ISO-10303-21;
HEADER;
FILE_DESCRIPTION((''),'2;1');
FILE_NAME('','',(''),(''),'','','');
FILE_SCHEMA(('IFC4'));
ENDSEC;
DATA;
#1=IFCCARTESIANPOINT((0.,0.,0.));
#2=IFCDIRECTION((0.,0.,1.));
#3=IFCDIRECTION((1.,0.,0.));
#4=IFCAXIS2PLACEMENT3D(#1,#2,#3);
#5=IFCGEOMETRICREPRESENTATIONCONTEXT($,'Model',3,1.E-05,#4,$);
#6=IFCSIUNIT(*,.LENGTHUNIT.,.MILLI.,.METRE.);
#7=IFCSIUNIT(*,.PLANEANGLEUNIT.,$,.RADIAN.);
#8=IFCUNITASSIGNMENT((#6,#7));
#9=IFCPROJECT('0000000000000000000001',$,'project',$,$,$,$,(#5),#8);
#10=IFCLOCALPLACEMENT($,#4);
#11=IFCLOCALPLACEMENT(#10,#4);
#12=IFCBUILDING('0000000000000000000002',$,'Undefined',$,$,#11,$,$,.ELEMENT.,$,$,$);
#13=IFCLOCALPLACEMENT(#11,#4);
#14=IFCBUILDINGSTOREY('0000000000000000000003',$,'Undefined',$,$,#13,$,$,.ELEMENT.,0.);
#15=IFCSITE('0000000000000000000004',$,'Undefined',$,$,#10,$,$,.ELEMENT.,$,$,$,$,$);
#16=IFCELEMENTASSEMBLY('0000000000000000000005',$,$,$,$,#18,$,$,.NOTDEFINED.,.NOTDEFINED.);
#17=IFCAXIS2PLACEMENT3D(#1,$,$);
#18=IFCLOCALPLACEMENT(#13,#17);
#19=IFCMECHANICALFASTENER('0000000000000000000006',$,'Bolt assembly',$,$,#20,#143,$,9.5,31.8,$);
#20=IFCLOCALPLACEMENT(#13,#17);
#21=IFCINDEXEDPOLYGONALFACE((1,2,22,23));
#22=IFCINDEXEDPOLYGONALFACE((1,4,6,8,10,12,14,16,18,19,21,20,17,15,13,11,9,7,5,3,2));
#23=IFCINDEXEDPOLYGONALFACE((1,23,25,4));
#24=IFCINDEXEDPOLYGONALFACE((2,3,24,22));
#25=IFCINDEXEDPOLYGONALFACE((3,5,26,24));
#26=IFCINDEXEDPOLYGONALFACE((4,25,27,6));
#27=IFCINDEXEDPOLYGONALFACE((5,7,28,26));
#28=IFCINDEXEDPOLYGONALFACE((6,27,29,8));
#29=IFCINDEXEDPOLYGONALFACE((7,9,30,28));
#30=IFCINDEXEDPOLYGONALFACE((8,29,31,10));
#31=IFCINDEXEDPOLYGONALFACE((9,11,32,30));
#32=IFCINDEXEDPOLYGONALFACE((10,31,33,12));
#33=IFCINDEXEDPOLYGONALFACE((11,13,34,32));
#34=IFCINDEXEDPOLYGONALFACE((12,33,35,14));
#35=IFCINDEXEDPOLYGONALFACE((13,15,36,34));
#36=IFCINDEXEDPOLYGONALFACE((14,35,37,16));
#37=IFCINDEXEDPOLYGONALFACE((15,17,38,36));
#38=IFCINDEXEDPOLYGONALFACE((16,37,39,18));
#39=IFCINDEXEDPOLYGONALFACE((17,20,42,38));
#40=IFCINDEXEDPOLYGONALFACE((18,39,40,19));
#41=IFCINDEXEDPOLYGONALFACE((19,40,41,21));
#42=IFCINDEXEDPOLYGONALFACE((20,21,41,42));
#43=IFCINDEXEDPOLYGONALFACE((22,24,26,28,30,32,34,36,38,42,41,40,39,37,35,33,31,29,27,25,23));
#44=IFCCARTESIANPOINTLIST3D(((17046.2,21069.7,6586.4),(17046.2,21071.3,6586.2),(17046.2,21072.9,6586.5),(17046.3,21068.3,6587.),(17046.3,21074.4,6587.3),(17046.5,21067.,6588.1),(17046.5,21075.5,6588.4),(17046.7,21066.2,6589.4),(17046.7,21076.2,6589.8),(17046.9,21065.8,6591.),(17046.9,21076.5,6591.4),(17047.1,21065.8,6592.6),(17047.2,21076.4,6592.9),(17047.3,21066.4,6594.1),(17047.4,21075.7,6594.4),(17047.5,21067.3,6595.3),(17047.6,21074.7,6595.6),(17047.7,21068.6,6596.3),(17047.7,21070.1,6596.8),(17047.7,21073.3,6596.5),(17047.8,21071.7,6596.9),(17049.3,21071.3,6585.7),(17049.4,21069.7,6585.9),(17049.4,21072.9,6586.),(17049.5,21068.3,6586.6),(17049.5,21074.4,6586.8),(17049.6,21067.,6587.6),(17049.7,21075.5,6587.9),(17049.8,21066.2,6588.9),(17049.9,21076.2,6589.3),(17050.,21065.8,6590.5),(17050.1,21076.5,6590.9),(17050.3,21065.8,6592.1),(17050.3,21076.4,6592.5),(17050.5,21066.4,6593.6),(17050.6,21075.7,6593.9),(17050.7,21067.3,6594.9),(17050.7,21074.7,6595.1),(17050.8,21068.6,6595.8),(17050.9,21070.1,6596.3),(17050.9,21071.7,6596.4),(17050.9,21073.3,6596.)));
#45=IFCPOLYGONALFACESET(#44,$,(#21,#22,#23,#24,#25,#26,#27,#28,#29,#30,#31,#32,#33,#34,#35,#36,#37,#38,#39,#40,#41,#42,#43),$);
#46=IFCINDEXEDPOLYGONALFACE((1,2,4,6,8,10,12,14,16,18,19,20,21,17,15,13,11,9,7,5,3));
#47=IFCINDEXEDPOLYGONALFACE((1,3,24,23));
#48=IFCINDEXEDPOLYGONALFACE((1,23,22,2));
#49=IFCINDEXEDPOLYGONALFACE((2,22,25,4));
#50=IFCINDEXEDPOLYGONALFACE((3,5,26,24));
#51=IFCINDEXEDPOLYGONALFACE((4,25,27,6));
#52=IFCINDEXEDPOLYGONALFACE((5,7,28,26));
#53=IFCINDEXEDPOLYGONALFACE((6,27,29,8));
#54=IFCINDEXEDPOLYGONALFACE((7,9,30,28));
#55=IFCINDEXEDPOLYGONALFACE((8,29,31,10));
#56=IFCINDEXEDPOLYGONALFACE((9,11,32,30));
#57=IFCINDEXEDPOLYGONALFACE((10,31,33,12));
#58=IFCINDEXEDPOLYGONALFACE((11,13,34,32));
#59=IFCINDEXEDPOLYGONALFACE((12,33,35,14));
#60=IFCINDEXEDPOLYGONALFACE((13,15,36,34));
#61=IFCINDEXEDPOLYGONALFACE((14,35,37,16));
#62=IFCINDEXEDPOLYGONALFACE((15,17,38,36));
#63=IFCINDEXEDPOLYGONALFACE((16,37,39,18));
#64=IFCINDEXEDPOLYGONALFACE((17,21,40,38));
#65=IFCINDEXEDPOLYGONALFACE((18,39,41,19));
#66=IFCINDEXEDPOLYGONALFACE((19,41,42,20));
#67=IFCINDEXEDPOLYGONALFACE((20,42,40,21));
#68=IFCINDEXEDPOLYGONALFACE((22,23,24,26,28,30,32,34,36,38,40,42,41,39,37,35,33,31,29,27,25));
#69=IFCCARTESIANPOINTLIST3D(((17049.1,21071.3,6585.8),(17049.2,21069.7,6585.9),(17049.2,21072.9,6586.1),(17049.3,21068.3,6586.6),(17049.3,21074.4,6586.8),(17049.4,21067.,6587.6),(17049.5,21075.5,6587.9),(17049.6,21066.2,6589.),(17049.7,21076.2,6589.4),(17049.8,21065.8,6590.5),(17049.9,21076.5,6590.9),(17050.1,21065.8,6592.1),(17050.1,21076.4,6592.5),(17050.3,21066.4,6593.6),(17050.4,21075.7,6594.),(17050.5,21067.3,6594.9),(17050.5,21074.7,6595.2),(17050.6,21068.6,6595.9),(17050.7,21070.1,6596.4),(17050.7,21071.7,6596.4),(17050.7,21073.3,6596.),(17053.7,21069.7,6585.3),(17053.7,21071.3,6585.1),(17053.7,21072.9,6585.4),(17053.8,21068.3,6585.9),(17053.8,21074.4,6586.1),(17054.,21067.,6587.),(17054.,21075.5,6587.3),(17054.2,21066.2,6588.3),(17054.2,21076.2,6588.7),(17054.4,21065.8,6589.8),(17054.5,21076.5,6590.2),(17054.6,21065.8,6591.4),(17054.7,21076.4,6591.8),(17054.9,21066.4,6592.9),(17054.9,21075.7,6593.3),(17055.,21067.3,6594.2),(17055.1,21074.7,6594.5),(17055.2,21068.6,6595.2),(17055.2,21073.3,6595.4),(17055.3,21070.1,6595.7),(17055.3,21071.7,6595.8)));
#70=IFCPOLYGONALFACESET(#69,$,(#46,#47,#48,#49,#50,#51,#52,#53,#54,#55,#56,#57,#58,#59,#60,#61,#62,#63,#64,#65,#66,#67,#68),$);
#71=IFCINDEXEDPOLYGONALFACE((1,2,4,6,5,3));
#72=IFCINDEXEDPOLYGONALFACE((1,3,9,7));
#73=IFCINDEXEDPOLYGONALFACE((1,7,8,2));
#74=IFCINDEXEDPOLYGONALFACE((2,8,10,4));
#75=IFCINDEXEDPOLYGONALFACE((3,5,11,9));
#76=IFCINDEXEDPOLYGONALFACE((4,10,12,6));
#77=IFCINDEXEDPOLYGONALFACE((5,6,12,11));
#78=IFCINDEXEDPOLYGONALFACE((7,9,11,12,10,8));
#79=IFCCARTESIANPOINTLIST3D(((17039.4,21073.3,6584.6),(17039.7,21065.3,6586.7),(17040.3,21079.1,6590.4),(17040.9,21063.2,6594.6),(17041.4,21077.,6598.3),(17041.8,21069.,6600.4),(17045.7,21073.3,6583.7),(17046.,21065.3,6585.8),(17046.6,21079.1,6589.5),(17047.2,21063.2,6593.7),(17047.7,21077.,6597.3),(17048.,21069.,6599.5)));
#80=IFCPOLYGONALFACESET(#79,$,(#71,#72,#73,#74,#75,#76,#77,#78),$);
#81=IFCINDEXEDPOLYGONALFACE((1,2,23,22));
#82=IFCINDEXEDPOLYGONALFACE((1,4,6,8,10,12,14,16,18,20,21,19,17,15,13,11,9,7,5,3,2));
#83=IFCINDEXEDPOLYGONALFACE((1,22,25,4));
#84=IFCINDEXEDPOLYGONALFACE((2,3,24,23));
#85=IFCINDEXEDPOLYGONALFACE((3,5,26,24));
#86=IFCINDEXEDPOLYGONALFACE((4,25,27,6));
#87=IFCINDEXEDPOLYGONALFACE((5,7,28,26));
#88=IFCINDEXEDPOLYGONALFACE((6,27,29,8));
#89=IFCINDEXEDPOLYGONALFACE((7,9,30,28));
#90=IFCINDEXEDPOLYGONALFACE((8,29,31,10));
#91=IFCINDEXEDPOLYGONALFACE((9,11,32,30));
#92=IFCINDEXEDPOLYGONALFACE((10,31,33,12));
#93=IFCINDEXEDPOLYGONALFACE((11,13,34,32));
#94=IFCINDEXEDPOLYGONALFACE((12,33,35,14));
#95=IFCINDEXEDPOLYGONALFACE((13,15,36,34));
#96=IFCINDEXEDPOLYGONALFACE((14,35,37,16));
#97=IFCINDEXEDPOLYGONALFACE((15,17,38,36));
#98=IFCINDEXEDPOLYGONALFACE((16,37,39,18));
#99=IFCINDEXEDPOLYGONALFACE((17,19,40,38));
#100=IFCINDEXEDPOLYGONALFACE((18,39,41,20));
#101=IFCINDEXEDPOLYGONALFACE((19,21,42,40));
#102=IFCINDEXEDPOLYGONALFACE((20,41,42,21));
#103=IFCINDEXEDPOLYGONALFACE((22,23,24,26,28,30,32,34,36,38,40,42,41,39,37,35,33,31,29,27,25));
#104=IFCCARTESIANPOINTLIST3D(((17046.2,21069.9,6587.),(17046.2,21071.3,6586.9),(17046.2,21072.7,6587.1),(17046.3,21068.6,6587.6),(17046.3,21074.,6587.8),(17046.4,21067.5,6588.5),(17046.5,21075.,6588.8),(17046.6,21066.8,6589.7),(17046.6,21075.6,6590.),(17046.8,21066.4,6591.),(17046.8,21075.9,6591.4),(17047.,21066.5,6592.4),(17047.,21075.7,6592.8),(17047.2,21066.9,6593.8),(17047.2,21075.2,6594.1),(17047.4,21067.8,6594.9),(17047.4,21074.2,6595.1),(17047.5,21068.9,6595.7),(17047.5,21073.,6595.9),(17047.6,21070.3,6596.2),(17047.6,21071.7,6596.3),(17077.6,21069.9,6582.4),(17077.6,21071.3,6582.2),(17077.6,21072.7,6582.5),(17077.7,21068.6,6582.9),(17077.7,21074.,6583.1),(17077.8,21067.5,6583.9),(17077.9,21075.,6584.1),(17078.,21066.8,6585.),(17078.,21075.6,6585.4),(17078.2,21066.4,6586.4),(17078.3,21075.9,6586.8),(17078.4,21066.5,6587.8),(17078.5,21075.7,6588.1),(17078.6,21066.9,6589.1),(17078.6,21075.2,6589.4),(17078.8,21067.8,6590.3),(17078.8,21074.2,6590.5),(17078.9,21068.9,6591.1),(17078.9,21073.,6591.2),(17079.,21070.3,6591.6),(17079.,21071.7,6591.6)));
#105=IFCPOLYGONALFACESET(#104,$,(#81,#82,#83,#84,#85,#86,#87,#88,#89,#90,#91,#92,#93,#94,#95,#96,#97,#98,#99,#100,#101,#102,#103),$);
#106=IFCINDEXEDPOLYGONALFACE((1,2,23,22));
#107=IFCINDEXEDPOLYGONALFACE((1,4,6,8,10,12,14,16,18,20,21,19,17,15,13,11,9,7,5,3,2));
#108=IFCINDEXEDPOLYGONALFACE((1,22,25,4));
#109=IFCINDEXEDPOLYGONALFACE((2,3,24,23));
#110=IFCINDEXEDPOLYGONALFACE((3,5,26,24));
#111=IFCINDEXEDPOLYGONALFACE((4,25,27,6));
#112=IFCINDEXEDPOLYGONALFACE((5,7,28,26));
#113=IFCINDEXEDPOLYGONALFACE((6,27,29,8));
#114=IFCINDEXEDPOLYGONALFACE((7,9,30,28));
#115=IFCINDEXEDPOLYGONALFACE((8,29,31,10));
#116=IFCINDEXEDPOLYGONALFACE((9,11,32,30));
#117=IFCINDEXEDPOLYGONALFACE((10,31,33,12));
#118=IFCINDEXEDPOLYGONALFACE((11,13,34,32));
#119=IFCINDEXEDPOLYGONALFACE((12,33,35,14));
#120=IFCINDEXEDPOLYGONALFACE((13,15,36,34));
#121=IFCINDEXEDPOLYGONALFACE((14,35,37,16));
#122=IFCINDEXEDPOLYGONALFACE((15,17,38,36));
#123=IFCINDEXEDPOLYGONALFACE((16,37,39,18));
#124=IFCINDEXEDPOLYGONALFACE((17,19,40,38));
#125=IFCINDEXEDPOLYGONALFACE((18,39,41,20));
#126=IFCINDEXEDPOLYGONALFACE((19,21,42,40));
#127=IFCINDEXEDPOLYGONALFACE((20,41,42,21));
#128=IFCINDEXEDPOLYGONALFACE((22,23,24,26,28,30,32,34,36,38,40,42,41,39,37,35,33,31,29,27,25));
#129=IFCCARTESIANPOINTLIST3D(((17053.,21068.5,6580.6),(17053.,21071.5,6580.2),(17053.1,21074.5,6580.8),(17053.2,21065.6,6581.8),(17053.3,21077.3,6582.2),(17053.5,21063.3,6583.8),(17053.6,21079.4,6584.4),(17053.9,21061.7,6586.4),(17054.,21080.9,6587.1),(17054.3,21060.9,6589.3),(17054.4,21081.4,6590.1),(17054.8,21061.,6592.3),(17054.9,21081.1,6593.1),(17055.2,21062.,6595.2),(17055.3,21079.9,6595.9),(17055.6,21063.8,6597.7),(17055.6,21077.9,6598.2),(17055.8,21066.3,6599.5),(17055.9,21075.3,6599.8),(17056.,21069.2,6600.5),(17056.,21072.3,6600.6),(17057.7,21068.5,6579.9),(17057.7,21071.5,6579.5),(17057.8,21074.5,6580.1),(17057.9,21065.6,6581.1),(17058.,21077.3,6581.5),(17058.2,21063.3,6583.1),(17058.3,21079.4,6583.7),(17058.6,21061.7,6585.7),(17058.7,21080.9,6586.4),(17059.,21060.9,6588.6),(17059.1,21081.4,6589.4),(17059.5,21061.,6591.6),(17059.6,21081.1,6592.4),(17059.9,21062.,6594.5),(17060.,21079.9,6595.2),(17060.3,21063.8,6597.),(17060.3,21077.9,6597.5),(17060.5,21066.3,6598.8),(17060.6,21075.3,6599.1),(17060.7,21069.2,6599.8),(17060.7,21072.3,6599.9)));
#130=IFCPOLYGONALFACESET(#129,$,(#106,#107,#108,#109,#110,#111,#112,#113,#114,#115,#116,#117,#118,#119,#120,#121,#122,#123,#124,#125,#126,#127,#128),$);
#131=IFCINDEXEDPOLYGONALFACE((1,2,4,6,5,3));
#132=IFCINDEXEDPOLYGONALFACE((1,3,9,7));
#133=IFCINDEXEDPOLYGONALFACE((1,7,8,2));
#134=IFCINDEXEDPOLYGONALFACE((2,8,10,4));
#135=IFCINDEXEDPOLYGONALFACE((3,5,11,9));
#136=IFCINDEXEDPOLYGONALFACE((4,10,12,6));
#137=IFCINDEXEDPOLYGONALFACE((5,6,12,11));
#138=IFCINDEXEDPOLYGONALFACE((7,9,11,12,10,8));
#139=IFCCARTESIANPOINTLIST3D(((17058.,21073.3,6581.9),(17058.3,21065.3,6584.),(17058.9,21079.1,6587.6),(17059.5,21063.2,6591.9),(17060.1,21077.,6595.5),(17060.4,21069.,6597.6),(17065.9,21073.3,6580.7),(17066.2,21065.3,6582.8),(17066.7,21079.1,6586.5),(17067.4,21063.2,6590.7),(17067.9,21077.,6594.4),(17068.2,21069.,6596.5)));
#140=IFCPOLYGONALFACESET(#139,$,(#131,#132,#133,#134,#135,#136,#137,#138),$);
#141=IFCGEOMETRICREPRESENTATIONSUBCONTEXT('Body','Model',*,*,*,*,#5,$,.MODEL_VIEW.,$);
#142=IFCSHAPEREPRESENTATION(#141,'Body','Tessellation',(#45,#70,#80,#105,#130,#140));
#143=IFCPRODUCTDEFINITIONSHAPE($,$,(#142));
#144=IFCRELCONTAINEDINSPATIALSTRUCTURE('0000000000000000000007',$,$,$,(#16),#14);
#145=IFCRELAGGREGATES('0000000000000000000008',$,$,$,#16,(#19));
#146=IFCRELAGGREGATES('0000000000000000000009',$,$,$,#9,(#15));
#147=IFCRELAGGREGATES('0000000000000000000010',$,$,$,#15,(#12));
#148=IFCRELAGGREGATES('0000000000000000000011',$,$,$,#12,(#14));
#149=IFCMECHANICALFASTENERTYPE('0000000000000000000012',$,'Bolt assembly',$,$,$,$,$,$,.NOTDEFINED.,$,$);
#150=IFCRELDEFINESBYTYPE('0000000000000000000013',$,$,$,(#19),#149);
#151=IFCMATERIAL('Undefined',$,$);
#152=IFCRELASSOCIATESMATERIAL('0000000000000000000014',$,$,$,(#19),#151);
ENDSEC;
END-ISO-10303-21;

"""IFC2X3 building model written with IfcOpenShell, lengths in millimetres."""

from ifc_helpers import new_model, si_unit, frame, origin_with_axes, origin_2d_with_axis, place, context, subcontext, project, spatial, polyline, circle, outline, extrude, source, transform, mapped, material, type_object, element, aggregate, save


model = new_model("IFC2X3")

# Units and contexts
model_context = context("Model", 3, precision=1e-05, world=origin_with_axes())
body_context = subcontext(model_context, "Body", "Model", "MODEL_VIEW")
ifc_project = project(units=[si_unit("LENGTHUNIT", "METRE", prefix="MILLI"), si_unit("PLANEANGLEUNIT", "RADIAN")], contexts=[model_context])

# Site, building, storey
site_placement = place(None, origin_with_axes())
site = spatial("IfcSite", under=ifc_project, at=site_placement, Name="Undefined", CompositionType="ELEMENT")
building_placement = place(site_placement, origin_with_axes())
building = spatial("IfcBuilding", under=site, at=building_placement, Name="Undefined", CompositionType="ELEMENT")
storey_placement = place(building_placement, origin_with_axes())
storey = spatial("IfcBuildingStorey", under=building, at=storey_placement, Name="Undefined", CompositionType="ELEMENT", Elevation=0.0)

# Element assembly
assembly_1_placement = place(storey_placement, origin_with_axes())
assembly_1 = element("IfcElementAssembly", 1, at=assembly_1_placement, inside=storey, AssemblyPlace="NOTDEFINED", PredefinedType="NOTDEFINED")

# Shared definitions
ifc_material_1 = material(Name="Undefined")
mechanical_fastener_type = type_object("IfcMechanicalFastenerType", Name="Bolt assembly")

# Mechanical fastener
shared_shape_1 = source(origin_with_axes(), body_context, "Body", "SweptSolid", [
    extrude(circle(Radius=5.4, at=origin_2d_with_axis()), frame((0.0, -3.1, 0.0), z_axis=(0.0, 1.0, 0.0), x_axis=(1.0, 0.0, 0.0)), (0.0, 0.0, 1.0), 3.2),
    extrude(circle(Radius=5.4, at=origin_2d_with_axis()), frame((0.0, -0.1, 0.0), z_axis=(0.0, 1.0, 0.0), x_axis=(1.0, 0.0, 0.0)), (0.0, 0.0, 1.0), 4.6),
    extrude(outline(polyline([(7.1, -4.1), (7.1, 4.1), (0.0, 8.2), (-7.1, 4.1), (-7.1, -4.1), (0.0, -8.2), (7.1, -4.1)])), frame((0.0, -9.6, 0.0), z_axis=(0.0, 1.0, 0.0), x_axis=(1.0, 0.0, 0.0)), (0.0, 0.0, 1.0), 6.3),
    extrude(circle(Radius=4.8, at=origin_2d_with_axis()), frame((0.0, -3.2, 0.0), z_axis=(0.0, 1.0, 0.0), x_axis=(1.0, 0.0, 0.0)), (0.0, 0.0, 1.0), 31.8),
    extrude(circle(Radius=10.3, at=origin_2d_with_axis()), frame((0.0, 4.5, 0.0), z_axis=(0.0, 1.0, 0.0), x_axis=(1.0, 0.0, 0.0)), (0.0, 0.0, 1.0), 4.8),
    extrude(outline(polyline([(7.1, -4.1), (7.1, 4.1), (0.0, 8.2), (-7.1, 4.1), (-7.1, -4.1), (0.0, -8.2), (7.1, -4.1)])), frame((0.0, 9.3, 0.0), z_axis=(0.0, 1.0, 0.0), x_axis=(1.0, 0.0, 0.0)), (0.0, 0.0, 1.0), 7.9),
])
mechanical_fastener_1_placement = place(assembly_1_placement, frame((17050.0, 21071.1, 6591.1), z_axis=(0.10338, 0.707107, 0.699509), x_axis=(0.10338, -0.707107, 0.699509)))
mechanical_fastener_1 = element("IfcMechanicalFastener", 2, at=mechanical_fastener_1_placement, type_object=mechanical_fastener_type, material=ifc_material_1, Name="Bolt assembly", NominalDiameter=9.5, NominalLength=31.8, context=body_context, shape_type="MappedRepresentation", body=[
    mapped(shared_shape_1, transform((0.0, 0.0, 0.0))),
])
aggregate(assembly_1, [mechanical_fastener_1])

save(model, "model.ifc")
